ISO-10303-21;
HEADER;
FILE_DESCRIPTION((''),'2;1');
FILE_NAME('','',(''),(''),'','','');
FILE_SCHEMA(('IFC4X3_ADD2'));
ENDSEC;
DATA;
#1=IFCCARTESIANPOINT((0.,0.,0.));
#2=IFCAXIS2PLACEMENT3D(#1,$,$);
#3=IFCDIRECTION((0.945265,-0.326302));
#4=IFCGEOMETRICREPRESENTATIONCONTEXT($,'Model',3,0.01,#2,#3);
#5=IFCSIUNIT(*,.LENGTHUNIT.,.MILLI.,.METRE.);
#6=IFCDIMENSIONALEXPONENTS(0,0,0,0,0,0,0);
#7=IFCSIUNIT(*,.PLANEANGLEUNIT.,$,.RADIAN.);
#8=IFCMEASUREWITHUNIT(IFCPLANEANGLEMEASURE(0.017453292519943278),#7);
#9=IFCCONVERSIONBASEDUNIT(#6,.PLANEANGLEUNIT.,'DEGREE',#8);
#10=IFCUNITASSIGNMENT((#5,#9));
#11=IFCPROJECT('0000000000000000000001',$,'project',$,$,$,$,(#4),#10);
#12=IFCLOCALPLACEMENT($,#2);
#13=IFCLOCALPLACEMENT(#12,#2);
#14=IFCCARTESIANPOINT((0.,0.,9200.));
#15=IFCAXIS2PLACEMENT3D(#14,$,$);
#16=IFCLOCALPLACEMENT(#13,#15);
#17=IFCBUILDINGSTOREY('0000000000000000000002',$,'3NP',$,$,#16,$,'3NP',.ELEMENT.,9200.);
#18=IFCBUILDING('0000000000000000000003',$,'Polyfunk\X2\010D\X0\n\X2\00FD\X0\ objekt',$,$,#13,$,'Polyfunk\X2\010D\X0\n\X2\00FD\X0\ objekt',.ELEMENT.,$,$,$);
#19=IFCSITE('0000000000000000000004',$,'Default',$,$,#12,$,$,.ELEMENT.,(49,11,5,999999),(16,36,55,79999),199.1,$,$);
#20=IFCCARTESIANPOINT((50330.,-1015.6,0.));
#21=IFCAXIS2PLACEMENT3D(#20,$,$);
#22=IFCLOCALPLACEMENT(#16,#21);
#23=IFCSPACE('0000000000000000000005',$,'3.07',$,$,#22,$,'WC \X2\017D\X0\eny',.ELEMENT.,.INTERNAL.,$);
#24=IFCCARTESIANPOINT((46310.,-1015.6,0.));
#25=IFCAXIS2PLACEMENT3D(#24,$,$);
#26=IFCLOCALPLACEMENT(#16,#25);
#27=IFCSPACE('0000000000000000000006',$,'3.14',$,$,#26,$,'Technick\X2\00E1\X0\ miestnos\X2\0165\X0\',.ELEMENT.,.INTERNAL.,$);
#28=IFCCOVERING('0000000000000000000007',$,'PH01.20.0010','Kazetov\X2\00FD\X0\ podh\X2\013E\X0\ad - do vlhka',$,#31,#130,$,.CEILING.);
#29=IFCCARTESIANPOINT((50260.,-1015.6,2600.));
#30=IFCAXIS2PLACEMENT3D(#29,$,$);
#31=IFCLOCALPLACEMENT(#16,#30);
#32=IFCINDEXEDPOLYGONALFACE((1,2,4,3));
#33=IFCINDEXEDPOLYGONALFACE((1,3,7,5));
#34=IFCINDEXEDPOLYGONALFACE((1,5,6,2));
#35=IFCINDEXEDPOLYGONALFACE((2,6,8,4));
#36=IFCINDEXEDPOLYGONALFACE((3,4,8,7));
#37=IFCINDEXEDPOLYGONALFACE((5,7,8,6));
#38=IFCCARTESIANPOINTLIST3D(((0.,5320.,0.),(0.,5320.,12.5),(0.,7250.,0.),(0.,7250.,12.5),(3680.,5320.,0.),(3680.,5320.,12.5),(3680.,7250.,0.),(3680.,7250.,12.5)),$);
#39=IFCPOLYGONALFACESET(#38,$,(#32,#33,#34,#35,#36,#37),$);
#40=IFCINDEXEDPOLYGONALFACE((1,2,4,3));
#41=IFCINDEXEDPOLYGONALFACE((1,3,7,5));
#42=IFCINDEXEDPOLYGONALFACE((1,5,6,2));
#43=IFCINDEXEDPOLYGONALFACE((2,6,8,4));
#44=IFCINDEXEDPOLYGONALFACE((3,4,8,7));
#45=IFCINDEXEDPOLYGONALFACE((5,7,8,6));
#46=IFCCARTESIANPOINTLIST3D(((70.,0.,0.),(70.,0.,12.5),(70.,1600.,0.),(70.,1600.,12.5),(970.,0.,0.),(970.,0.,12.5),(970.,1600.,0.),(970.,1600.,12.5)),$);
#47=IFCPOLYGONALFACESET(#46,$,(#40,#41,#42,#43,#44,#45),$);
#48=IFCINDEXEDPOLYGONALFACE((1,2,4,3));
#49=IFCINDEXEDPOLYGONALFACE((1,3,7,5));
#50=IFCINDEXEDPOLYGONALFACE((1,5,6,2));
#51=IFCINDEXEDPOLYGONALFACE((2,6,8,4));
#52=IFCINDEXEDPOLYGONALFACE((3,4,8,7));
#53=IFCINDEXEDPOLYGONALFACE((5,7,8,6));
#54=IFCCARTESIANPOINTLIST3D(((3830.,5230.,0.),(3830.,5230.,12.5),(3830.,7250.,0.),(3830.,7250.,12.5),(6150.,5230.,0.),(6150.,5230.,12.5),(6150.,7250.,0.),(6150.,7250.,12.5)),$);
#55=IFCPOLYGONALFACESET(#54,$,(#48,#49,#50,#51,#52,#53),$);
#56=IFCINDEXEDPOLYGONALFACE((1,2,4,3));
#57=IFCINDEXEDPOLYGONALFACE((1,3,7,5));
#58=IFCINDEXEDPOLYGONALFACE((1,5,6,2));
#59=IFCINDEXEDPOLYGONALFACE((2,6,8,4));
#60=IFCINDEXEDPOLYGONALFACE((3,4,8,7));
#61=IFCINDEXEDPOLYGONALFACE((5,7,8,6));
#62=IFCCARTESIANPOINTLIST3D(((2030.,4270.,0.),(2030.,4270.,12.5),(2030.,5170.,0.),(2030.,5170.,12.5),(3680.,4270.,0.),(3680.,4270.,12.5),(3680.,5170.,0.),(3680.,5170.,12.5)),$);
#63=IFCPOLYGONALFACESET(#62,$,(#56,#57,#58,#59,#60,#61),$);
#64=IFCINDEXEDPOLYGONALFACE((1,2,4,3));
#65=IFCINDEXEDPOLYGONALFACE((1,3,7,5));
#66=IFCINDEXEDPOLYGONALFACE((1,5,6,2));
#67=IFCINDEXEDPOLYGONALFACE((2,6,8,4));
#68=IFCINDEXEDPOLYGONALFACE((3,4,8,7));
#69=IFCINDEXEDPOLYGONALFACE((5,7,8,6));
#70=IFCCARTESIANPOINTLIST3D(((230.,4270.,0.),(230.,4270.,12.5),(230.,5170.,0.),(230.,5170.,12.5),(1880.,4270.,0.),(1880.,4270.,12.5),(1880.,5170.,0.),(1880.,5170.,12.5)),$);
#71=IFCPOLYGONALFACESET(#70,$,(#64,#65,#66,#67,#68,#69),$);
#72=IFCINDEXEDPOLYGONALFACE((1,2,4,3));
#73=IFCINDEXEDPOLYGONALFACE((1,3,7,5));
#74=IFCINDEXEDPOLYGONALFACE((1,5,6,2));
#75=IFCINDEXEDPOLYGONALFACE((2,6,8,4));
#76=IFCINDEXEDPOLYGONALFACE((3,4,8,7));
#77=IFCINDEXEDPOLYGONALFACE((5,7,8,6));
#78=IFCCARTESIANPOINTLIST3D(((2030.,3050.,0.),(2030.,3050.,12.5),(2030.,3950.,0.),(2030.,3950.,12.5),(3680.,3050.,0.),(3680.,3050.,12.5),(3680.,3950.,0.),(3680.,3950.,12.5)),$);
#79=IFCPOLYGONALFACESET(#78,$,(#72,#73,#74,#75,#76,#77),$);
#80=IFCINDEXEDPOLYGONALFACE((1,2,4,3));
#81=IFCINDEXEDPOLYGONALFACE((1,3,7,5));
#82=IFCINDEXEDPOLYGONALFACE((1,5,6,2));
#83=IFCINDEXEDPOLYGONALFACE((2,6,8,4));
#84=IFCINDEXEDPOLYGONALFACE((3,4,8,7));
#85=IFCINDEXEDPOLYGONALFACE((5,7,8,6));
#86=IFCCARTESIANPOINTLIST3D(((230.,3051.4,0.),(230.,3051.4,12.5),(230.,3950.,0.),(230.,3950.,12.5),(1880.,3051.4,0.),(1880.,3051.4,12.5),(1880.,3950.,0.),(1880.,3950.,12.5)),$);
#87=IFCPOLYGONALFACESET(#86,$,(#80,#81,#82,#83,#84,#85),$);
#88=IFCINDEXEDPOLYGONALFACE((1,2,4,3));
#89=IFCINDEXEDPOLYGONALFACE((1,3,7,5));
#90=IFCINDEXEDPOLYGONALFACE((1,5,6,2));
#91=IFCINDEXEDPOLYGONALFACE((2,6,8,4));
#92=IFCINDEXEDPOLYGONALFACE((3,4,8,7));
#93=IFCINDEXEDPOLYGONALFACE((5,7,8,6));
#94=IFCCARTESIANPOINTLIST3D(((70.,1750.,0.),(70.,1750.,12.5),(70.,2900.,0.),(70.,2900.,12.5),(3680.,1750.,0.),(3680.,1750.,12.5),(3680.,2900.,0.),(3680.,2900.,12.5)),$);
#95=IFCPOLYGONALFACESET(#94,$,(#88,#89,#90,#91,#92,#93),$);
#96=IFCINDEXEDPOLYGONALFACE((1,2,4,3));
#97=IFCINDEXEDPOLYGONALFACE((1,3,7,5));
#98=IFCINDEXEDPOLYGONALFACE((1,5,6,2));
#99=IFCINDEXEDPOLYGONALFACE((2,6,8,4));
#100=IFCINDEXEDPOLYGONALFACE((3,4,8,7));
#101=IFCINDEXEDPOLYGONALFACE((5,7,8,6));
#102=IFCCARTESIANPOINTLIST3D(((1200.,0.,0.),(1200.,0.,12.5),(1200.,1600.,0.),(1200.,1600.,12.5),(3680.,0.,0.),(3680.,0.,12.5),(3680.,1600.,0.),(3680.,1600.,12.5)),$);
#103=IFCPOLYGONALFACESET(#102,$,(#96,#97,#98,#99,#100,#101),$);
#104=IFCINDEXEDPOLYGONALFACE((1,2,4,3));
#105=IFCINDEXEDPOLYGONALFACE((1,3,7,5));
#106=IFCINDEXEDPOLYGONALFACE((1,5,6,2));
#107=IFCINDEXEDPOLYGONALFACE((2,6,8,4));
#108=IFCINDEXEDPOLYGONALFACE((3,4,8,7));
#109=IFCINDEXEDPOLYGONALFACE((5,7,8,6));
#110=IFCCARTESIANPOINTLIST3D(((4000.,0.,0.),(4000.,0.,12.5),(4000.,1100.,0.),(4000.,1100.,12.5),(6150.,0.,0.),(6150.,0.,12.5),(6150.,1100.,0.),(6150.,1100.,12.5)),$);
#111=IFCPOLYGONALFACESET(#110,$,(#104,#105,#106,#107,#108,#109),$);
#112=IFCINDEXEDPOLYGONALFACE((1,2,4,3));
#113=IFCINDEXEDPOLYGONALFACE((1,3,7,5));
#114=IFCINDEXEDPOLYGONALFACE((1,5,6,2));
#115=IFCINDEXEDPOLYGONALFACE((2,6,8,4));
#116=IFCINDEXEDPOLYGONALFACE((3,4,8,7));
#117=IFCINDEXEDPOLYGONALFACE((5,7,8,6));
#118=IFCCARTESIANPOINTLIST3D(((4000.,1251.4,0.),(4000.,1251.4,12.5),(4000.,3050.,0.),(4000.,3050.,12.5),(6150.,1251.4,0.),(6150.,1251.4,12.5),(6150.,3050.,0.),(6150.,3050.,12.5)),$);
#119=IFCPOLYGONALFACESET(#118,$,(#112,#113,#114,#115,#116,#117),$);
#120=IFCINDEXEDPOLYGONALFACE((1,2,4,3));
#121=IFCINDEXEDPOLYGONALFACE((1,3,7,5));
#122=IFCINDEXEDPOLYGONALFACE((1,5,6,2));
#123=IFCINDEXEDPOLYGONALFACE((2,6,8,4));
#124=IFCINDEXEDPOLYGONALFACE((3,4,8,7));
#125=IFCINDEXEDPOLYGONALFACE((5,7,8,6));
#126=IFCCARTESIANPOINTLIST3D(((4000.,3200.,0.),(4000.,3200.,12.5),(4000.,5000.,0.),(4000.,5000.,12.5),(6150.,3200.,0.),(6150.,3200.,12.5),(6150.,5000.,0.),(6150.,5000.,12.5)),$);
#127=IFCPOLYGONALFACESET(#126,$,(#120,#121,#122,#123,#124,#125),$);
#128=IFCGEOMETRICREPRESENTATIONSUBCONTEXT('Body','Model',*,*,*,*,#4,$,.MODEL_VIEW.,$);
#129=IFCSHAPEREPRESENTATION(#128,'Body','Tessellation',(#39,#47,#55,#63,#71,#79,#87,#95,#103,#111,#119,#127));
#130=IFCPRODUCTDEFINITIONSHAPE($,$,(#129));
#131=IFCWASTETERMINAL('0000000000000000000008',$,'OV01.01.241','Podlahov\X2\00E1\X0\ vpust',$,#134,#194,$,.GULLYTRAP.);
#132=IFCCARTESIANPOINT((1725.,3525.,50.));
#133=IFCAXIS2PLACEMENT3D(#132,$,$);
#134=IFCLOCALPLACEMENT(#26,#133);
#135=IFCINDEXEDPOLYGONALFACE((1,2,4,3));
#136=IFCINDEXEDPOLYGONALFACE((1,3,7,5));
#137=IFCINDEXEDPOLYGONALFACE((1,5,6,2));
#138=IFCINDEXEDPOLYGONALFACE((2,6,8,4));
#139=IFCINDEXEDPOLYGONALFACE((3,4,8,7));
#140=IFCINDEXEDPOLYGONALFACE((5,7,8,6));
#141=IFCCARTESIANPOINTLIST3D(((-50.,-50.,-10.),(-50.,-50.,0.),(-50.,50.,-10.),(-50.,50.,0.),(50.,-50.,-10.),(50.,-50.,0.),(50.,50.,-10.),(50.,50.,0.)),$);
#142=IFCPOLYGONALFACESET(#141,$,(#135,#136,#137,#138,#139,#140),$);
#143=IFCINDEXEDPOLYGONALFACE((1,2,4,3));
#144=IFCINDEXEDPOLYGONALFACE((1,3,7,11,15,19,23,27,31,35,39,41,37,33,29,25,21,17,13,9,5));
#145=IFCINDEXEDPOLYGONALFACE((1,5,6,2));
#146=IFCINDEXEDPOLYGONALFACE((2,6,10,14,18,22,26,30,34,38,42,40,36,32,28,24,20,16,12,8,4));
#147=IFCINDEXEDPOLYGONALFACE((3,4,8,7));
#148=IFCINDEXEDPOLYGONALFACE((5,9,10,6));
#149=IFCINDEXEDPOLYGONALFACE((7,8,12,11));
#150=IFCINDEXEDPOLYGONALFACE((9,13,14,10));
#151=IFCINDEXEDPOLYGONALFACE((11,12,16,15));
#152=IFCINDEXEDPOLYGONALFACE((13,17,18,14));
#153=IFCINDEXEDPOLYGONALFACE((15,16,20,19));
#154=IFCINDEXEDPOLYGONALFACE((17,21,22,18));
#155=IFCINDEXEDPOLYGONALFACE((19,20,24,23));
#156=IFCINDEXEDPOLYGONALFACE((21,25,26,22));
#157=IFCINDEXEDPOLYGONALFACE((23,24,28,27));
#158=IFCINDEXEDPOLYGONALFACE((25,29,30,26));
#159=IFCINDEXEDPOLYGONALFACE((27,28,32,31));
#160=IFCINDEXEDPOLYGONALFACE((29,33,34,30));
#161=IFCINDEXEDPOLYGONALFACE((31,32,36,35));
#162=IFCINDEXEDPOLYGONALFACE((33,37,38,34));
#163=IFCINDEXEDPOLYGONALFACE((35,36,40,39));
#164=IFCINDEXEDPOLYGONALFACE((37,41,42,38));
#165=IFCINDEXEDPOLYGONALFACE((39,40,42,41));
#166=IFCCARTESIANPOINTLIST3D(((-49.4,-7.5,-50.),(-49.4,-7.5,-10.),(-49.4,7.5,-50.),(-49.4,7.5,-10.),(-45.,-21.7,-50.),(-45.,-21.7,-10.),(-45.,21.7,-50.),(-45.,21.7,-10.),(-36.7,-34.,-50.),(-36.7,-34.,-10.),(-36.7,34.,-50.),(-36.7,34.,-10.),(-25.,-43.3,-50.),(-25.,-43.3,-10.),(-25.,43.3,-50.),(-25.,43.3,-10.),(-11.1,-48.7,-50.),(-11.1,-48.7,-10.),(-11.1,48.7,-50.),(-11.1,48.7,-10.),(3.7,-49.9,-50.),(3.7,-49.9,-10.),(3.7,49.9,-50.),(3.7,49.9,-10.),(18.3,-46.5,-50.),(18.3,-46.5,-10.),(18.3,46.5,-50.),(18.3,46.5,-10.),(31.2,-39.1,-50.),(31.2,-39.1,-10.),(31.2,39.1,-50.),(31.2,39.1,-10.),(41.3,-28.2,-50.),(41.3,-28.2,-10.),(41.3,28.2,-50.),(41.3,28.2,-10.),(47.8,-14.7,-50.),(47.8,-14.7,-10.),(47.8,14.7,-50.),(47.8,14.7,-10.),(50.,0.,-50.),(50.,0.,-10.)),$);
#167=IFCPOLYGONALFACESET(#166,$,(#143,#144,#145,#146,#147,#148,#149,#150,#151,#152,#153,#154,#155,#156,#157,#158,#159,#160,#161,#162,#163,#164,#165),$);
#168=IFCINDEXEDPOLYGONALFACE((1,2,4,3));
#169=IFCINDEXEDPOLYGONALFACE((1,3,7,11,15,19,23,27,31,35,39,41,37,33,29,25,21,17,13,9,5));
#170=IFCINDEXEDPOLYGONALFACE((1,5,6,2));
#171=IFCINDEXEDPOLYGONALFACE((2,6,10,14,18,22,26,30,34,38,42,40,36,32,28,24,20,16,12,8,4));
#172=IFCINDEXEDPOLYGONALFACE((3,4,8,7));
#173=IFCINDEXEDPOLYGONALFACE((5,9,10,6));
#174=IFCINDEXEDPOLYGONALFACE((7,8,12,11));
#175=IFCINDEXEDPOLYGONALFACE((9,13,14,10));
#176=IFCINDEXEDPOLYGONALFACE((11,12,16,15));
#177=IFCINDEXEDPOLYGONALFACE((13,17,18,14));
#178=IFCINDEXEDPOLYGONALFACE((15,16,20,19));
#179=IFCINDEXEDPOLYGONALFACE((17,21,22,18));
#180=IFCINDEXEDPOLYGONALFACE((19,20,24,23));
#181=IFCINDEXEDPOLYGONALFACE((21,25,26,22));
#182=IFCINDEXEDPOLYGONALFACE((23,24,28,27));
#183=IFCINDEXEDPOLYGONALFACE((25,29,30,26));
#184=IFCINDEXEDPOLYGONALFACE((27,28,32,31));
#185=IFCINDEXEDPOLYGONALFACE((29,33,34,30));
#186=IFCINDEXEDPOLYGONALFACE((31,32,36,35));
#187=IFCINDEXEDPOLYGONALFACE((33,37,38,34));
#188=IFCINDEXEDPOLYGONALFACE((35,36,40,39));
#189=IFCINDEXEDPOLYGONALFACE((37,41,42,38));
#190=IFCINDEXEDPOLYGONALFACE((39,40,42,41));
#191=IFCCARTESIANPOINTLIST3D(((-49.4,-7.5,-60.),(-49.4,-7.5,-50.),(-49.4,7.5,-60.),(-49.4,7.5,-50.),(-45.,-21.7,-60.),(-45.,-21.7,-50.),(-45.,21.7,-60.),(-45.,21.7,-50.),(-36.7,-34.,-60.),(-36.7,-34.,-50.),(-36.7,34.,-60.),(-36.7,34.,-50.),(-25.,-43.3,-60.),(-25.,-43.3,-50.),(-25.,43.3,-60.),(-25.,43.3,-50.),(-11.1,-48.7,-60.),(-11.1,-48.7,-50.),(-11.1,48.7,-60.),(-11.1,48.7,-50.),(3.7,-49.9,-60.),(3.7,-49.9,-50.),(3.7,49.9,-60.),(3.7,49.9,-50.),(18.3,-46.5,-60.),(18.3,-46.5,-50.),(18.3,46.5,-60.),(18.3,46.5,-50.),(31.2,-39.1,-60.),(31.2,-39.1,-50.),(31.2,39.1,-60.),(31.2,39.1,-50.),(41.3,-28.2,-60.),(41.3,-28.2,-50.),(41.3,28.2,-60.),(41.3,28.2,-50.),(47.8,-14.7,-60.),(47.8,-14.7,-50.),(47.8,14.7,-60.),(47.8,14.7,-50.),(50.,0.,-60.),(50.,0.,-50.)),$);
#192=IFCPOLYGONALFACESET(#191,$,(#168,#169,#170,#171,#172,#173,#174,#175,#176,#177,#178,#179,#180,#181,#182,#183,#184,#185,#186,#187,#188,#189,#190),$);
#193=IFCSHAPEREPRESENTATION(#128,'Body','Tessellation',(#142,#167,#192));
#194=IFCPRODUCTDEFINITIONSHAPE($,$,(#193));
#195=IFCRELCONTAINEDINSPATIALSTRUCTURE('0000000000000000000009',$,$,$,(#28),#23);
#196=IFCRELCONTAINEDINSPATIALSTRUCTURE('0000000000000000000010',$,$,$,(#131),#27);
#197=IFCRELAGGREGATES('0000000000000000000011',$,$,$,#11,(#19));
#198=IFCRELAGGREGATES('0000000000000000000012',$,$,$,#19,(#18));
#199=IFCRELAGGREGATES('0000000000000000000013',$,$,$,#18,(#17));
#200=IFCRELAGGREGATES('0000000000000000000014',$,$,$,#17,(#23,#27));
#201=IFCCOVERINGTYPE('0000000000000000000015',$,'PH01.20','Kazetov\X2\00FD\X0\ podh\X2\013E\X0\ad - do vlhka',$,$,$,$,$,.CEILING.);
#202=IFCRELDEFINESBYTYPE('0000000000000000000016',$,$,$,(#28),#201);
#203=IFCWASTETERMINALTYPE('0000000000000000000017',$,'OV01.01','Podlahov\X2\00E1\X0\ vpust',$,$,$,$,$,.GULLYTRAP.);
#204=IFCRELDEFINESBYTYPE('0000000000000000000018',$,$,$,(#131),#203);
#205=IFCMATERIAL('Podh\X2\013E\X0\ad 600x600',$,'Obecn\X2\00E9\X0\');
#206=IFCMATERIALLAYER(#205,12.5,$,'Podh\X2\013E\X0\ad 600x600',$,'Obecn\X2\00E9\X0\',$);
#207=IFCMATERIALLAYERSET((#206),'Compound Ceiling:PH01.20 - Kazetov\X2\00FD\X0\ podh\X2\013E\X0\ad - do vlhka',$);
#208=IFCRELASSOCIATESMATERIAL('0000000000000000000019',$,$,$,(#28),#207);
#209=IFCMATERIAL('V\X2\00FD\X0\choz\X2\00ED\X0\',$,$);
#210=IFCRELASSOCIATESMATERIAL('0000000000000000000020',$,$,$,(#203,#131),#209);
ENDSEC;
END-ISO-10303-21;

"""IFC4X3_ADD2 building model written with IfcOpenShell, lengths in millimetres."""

from ifc_helpers import new_model, entity, si_unit, converted_unit, direction, frame, frame_2d, origin, origin_2d_with_axis, place, context, subcontext, project, spatial, rectangle, circle, extrude, source, transform, mapped, material, layer, layer_set, layer_usage, type_object, type_shapes, element, save


model = new_model("IFC4X3_ADD2")

# Units and contexts
model_context = context("Model", 3, precision=0.01, world=origin(), true_north=direction((0.945265, -0.326302)))
body_context = subcontext(model_context, "Body", "Model", "MODEL_VIEW")
ifc_project = project(units=[si_unit("LENGTHUNIT", "METRE", prefix="MILLI"), converted_unit("PLANEANGLEUNIT", "DEGREE", entity("IfcPlaneAngleMeasure", 0.017453292519943278), si_unit("PLANEANGLEUNIT", "RADIAN"), dimensions=[0, 0, 0, 0, 0, 0, 0])], contexts=[model_context])

# Site, building, storey
site_placement = place(None, origin())
site = spatial("IfcSite", under=ifc_project, at=site_placement, Name="Default", CompositionType="ELEMENT", RefLatitude=(49, 11, 5, 999999), RefLongitude=(16, 36, 55, 79999), RefElevation=199.1)
building_placement = place(site_placement, origin())
building = spatial("IfcBuilding", under=site, at=building_placement, Name="Polyfunkčný objekt", LongName="Polyfunkčný objekt", CompositionType="ELEMENT")
storey_placement = place(building_placement, frame((0.0, 0.0, 9200.0)))
storey = spatial("IfcBuildingStorey", under=building, at=storey_placement, Name="3NP", LongName="3NP", CompositionType="ELEMENT", Elevation=9200.0)

# Shared definitions
space_1_placement = place(storey_placement, frame((50330.0, -1015.6, 0.0)))
space_1 = spatial("IfcSpace", under=storey, at=space_1_placement, Name="3.07", LongName="WC Ženy", CompositionType="ELEMENT", PredefinedType="INTERNAL")

# Covering
ifc_material_1 = material(Name="Podhľad 600x600", Category="Obecné")
ifc_layer_1 = layer(ifc_material_1, 12.5, Name="Podhľad 600x600", Category="Obecné")
ifc_layer_set_1 = layer_set([ifc_layer_1], Name="Compound Ceiling:PH01.20 - Kazetový podhľad - do vlhka")
ifc_layer_usage_1 = layer_usage(ifc_layer_set_1, "AXIS3", "NEGATIVE", 0.0)
covering_type = type_object("IfcCoveringType", Name="PH01.20", Description="Kazetový podhľad - do vlhka", PredefinedType="CEILING")
covering_placement = place(storey_placement, frame((50260.0, -1015.6, 2600.0)))
element("IfcCovering", 1, at=covering_placement, inside=space_1, type_object=covering_type, material=ifc_layer_usage_1, Name="PH01.20.0010", Description="Kazetový podhľad - do vlhka", PredefinedType="CEILING", context=body_context, shape_type="SweptSolid", body=[
    extrude(rectangle(XDim=1930.0, YDim=3680.0, at=frame_2d((0.0, 0.0), x_axis=(1.0, 0.0))), frame((1840.0, 6285.0, 0.0), z_axis=(0.0, 0.0, 1.0), x_axis=(0.0, -1.0, 0.0)), (0.0, 0.0, 1.0), 12.5),
    extrude(rectangle(XDim=1600.0, YDim=900.0, at=origin_2d_with_axis()), frame((520.0, 800.0, 0.0), z_axis=(0.0, 0.0, 1.0), x_axis=(0.0, 1.0, 0.0)), (0.0, 0.0, 1.0), 12.5),
    extrude(rectangle(XDim=2320.0, YDim=2020.0, at=frame_2d((0.0, 0.0), x_axis=(1.0, 0.0))), frame((4990.0, 6240.0, 0.0), z_axis=(0.0, 0.0, 1.0), x_axis=(-1.0, 0.0, 0.0)), (0.0, 0.0, 1.0), 12.5),
    extrude(rectangle(XDim=900.0, YDim=1650.0, at=frame_2d((0.0, 0.0), x_axis=(1.0, 0.0))), frame((2855.0, 4720.0, 0.0), z_axis=(0.0, 0.0, 1.0), x_axis=(0.0, 1.0, 0.0)), (0.0, 0.0, 1.0), 12.5),
    extrude(rectangle(XDim=1650.0, YDim=900.0, at=frame_2d((0.0, 0.0), x_axis=(1.0, 0.0))), frame((1055.0, 4720.0, 0.0), z_axis=(0.0, 0.0, 1.0), x_axis=(-1.0, 0.0, 0.0)), (0.0, 0.0, 1.0), 12.5),
    extrude(rectangle(XDim=900.0, YDim=1650.0, at=frame_2d((0.0, 0.0), x_axis=(1.0, 0.0))), frame((2855.0, 3500.0, 0.0), z_axis=(0.0, 0.0, 1.0), x_axis=(0.0, -1.0, 0.0)), (0.0, 0.0, 1.0), 12.5),
    extrude(rectangle(XDim=1650.0, YDim=898.6, at=frame_2d((0.0, 0.0), x_axis=(1.0, 0.0))), frame((1055.0, 3500.7, 0.0), z_axis=(0.0, 0.0, 1.0), x_axis=(-1.0, 0.0, 0.0)), (0.0, 0.0, 1.0), 12.5),
    extrude(rectangle(XDim=3610.0, YDim=1150.0, at=frame_2d((0.0, 0.0), x_axis=(1.0, 0.0))), frame((1875.0, 2325.0, 0.0), z_axis=(0.0, 0.0, 1.0), x_axis=(-1.0, 0.0, 0.0)), (0.0, 0.0, 1.0), 12.5),
    extrude(rectangle(XDim=2480.0, YDim=1600.0, at=origin_2d_with_axis()), frame((2440.0, 800.0, 0.0), z_axis=(0.0, 0.0, 1.0), x_axis=(-1.0, 0.0, 0.0)), (0.0, 0.0, 1.0), 12.5),
    extrude(rectangle(XDim=1100.0, YDim=2150.0, at=frame_2d((0.0, 0.0), x_axis=(1.0, 0.0))), frame((5075.0, 550.0, 0.0), z_axis=(0.0, 0.0, 1.0), x_axis=(0.0, 1.0, 0.0)), (0.0, 0.0, 1.0), 12.5),
    extrude(rectangle(XDim=1798.6, YDim=2150.0, at=origin_2d_with_axis()), frame((5075.0, 2150.7, 0.0), z_axis=(0.0, 0.0, 1.0), x_axis=(0.0, 1.0, 0.0)), (0.0, 0.0, 1.0), 12.5),
    extrude(rectangle(XDim=1800.0, YDim=2150.0, at=frame_2d((0.0, 0.0), x_axis=(1.0, 0.0))), frame((5075.0, 4100.0, 0.0), z_axis=(0.0, 0.0, 1.0), x_axis=(0.0, 1.0, 0.0)), (0.0, 0.0, 1.0), 12.5),
])

# Shared definitions
space_2_placement = place(storey_placement, frame((46310.0, -1015.6, 0.0)))
space_2 = spatial("IfcSpace", under=storey, at=space_2_placement, Name="3.14", LongName="Technická miestnosť", CompositionType="ELEMENT", PredefinedType="INTERNAL")

# Waste terminal
ifc_material_2 = material(Name="Výchozí")
waste_terminal_type = type_object("IfcWasteTerminalType", Name="OV01.01", Description="Podlahová vpust", PredefinedType="GULLYTRAP", material=ifc_material_2)
shared_shape_1 = source(origin(), body_context, "Body", "SweptSolid", [
    extrude(rectangle(XDim=100.0, YDim=100.0, at=frame_2d((0.0, 0.0), x_axis=(1.0, 0.0))), frame((0.0, 0.0, -10.0), z_axis=(0.0, 0.0, 1.0), x_axis=(-1.0, 0.0, 0.0)), (0.0, 0.0, 1.0), 10.0),
    extrude(circle(Radius=50.0, at=frame_2d((0.0, 0.0), x_axis=(1.0, 0.0))), frame((0.0, 0.0, -50.0)), (0.0, 0.0, 1.0), 40.0),
    extrude(circle(Radius=50.0, at=frame_2d((0.0, 0.0), x_axis=(1.0, 0.0))), frame((0.0, 0.0, -60.0)), (0.0, 0.0, 1.0), 10.0),
])
type_shapes(waste_terminal_type, [shared_shape_1])
waste_terminal_placement = place(space_2_placement, frame((1725.0, 3525.0, 50.0)))
element("IfcWasteTerminal", 2, at=waste_terminal_placement, inside=space_2, type_object=waste_terminal_type, material=ifc_material_2, Name="OV01.01.241", Description="Podlahová vpust", PredefinedType="GULLYTRAP", context=body_context, shape_type="MappedRepresentation", body=[
    mapped(shared_shape_1, transform((0.0, 0.0, 0.0), scale=1.0)),
])

save(model, "model.ifc")
